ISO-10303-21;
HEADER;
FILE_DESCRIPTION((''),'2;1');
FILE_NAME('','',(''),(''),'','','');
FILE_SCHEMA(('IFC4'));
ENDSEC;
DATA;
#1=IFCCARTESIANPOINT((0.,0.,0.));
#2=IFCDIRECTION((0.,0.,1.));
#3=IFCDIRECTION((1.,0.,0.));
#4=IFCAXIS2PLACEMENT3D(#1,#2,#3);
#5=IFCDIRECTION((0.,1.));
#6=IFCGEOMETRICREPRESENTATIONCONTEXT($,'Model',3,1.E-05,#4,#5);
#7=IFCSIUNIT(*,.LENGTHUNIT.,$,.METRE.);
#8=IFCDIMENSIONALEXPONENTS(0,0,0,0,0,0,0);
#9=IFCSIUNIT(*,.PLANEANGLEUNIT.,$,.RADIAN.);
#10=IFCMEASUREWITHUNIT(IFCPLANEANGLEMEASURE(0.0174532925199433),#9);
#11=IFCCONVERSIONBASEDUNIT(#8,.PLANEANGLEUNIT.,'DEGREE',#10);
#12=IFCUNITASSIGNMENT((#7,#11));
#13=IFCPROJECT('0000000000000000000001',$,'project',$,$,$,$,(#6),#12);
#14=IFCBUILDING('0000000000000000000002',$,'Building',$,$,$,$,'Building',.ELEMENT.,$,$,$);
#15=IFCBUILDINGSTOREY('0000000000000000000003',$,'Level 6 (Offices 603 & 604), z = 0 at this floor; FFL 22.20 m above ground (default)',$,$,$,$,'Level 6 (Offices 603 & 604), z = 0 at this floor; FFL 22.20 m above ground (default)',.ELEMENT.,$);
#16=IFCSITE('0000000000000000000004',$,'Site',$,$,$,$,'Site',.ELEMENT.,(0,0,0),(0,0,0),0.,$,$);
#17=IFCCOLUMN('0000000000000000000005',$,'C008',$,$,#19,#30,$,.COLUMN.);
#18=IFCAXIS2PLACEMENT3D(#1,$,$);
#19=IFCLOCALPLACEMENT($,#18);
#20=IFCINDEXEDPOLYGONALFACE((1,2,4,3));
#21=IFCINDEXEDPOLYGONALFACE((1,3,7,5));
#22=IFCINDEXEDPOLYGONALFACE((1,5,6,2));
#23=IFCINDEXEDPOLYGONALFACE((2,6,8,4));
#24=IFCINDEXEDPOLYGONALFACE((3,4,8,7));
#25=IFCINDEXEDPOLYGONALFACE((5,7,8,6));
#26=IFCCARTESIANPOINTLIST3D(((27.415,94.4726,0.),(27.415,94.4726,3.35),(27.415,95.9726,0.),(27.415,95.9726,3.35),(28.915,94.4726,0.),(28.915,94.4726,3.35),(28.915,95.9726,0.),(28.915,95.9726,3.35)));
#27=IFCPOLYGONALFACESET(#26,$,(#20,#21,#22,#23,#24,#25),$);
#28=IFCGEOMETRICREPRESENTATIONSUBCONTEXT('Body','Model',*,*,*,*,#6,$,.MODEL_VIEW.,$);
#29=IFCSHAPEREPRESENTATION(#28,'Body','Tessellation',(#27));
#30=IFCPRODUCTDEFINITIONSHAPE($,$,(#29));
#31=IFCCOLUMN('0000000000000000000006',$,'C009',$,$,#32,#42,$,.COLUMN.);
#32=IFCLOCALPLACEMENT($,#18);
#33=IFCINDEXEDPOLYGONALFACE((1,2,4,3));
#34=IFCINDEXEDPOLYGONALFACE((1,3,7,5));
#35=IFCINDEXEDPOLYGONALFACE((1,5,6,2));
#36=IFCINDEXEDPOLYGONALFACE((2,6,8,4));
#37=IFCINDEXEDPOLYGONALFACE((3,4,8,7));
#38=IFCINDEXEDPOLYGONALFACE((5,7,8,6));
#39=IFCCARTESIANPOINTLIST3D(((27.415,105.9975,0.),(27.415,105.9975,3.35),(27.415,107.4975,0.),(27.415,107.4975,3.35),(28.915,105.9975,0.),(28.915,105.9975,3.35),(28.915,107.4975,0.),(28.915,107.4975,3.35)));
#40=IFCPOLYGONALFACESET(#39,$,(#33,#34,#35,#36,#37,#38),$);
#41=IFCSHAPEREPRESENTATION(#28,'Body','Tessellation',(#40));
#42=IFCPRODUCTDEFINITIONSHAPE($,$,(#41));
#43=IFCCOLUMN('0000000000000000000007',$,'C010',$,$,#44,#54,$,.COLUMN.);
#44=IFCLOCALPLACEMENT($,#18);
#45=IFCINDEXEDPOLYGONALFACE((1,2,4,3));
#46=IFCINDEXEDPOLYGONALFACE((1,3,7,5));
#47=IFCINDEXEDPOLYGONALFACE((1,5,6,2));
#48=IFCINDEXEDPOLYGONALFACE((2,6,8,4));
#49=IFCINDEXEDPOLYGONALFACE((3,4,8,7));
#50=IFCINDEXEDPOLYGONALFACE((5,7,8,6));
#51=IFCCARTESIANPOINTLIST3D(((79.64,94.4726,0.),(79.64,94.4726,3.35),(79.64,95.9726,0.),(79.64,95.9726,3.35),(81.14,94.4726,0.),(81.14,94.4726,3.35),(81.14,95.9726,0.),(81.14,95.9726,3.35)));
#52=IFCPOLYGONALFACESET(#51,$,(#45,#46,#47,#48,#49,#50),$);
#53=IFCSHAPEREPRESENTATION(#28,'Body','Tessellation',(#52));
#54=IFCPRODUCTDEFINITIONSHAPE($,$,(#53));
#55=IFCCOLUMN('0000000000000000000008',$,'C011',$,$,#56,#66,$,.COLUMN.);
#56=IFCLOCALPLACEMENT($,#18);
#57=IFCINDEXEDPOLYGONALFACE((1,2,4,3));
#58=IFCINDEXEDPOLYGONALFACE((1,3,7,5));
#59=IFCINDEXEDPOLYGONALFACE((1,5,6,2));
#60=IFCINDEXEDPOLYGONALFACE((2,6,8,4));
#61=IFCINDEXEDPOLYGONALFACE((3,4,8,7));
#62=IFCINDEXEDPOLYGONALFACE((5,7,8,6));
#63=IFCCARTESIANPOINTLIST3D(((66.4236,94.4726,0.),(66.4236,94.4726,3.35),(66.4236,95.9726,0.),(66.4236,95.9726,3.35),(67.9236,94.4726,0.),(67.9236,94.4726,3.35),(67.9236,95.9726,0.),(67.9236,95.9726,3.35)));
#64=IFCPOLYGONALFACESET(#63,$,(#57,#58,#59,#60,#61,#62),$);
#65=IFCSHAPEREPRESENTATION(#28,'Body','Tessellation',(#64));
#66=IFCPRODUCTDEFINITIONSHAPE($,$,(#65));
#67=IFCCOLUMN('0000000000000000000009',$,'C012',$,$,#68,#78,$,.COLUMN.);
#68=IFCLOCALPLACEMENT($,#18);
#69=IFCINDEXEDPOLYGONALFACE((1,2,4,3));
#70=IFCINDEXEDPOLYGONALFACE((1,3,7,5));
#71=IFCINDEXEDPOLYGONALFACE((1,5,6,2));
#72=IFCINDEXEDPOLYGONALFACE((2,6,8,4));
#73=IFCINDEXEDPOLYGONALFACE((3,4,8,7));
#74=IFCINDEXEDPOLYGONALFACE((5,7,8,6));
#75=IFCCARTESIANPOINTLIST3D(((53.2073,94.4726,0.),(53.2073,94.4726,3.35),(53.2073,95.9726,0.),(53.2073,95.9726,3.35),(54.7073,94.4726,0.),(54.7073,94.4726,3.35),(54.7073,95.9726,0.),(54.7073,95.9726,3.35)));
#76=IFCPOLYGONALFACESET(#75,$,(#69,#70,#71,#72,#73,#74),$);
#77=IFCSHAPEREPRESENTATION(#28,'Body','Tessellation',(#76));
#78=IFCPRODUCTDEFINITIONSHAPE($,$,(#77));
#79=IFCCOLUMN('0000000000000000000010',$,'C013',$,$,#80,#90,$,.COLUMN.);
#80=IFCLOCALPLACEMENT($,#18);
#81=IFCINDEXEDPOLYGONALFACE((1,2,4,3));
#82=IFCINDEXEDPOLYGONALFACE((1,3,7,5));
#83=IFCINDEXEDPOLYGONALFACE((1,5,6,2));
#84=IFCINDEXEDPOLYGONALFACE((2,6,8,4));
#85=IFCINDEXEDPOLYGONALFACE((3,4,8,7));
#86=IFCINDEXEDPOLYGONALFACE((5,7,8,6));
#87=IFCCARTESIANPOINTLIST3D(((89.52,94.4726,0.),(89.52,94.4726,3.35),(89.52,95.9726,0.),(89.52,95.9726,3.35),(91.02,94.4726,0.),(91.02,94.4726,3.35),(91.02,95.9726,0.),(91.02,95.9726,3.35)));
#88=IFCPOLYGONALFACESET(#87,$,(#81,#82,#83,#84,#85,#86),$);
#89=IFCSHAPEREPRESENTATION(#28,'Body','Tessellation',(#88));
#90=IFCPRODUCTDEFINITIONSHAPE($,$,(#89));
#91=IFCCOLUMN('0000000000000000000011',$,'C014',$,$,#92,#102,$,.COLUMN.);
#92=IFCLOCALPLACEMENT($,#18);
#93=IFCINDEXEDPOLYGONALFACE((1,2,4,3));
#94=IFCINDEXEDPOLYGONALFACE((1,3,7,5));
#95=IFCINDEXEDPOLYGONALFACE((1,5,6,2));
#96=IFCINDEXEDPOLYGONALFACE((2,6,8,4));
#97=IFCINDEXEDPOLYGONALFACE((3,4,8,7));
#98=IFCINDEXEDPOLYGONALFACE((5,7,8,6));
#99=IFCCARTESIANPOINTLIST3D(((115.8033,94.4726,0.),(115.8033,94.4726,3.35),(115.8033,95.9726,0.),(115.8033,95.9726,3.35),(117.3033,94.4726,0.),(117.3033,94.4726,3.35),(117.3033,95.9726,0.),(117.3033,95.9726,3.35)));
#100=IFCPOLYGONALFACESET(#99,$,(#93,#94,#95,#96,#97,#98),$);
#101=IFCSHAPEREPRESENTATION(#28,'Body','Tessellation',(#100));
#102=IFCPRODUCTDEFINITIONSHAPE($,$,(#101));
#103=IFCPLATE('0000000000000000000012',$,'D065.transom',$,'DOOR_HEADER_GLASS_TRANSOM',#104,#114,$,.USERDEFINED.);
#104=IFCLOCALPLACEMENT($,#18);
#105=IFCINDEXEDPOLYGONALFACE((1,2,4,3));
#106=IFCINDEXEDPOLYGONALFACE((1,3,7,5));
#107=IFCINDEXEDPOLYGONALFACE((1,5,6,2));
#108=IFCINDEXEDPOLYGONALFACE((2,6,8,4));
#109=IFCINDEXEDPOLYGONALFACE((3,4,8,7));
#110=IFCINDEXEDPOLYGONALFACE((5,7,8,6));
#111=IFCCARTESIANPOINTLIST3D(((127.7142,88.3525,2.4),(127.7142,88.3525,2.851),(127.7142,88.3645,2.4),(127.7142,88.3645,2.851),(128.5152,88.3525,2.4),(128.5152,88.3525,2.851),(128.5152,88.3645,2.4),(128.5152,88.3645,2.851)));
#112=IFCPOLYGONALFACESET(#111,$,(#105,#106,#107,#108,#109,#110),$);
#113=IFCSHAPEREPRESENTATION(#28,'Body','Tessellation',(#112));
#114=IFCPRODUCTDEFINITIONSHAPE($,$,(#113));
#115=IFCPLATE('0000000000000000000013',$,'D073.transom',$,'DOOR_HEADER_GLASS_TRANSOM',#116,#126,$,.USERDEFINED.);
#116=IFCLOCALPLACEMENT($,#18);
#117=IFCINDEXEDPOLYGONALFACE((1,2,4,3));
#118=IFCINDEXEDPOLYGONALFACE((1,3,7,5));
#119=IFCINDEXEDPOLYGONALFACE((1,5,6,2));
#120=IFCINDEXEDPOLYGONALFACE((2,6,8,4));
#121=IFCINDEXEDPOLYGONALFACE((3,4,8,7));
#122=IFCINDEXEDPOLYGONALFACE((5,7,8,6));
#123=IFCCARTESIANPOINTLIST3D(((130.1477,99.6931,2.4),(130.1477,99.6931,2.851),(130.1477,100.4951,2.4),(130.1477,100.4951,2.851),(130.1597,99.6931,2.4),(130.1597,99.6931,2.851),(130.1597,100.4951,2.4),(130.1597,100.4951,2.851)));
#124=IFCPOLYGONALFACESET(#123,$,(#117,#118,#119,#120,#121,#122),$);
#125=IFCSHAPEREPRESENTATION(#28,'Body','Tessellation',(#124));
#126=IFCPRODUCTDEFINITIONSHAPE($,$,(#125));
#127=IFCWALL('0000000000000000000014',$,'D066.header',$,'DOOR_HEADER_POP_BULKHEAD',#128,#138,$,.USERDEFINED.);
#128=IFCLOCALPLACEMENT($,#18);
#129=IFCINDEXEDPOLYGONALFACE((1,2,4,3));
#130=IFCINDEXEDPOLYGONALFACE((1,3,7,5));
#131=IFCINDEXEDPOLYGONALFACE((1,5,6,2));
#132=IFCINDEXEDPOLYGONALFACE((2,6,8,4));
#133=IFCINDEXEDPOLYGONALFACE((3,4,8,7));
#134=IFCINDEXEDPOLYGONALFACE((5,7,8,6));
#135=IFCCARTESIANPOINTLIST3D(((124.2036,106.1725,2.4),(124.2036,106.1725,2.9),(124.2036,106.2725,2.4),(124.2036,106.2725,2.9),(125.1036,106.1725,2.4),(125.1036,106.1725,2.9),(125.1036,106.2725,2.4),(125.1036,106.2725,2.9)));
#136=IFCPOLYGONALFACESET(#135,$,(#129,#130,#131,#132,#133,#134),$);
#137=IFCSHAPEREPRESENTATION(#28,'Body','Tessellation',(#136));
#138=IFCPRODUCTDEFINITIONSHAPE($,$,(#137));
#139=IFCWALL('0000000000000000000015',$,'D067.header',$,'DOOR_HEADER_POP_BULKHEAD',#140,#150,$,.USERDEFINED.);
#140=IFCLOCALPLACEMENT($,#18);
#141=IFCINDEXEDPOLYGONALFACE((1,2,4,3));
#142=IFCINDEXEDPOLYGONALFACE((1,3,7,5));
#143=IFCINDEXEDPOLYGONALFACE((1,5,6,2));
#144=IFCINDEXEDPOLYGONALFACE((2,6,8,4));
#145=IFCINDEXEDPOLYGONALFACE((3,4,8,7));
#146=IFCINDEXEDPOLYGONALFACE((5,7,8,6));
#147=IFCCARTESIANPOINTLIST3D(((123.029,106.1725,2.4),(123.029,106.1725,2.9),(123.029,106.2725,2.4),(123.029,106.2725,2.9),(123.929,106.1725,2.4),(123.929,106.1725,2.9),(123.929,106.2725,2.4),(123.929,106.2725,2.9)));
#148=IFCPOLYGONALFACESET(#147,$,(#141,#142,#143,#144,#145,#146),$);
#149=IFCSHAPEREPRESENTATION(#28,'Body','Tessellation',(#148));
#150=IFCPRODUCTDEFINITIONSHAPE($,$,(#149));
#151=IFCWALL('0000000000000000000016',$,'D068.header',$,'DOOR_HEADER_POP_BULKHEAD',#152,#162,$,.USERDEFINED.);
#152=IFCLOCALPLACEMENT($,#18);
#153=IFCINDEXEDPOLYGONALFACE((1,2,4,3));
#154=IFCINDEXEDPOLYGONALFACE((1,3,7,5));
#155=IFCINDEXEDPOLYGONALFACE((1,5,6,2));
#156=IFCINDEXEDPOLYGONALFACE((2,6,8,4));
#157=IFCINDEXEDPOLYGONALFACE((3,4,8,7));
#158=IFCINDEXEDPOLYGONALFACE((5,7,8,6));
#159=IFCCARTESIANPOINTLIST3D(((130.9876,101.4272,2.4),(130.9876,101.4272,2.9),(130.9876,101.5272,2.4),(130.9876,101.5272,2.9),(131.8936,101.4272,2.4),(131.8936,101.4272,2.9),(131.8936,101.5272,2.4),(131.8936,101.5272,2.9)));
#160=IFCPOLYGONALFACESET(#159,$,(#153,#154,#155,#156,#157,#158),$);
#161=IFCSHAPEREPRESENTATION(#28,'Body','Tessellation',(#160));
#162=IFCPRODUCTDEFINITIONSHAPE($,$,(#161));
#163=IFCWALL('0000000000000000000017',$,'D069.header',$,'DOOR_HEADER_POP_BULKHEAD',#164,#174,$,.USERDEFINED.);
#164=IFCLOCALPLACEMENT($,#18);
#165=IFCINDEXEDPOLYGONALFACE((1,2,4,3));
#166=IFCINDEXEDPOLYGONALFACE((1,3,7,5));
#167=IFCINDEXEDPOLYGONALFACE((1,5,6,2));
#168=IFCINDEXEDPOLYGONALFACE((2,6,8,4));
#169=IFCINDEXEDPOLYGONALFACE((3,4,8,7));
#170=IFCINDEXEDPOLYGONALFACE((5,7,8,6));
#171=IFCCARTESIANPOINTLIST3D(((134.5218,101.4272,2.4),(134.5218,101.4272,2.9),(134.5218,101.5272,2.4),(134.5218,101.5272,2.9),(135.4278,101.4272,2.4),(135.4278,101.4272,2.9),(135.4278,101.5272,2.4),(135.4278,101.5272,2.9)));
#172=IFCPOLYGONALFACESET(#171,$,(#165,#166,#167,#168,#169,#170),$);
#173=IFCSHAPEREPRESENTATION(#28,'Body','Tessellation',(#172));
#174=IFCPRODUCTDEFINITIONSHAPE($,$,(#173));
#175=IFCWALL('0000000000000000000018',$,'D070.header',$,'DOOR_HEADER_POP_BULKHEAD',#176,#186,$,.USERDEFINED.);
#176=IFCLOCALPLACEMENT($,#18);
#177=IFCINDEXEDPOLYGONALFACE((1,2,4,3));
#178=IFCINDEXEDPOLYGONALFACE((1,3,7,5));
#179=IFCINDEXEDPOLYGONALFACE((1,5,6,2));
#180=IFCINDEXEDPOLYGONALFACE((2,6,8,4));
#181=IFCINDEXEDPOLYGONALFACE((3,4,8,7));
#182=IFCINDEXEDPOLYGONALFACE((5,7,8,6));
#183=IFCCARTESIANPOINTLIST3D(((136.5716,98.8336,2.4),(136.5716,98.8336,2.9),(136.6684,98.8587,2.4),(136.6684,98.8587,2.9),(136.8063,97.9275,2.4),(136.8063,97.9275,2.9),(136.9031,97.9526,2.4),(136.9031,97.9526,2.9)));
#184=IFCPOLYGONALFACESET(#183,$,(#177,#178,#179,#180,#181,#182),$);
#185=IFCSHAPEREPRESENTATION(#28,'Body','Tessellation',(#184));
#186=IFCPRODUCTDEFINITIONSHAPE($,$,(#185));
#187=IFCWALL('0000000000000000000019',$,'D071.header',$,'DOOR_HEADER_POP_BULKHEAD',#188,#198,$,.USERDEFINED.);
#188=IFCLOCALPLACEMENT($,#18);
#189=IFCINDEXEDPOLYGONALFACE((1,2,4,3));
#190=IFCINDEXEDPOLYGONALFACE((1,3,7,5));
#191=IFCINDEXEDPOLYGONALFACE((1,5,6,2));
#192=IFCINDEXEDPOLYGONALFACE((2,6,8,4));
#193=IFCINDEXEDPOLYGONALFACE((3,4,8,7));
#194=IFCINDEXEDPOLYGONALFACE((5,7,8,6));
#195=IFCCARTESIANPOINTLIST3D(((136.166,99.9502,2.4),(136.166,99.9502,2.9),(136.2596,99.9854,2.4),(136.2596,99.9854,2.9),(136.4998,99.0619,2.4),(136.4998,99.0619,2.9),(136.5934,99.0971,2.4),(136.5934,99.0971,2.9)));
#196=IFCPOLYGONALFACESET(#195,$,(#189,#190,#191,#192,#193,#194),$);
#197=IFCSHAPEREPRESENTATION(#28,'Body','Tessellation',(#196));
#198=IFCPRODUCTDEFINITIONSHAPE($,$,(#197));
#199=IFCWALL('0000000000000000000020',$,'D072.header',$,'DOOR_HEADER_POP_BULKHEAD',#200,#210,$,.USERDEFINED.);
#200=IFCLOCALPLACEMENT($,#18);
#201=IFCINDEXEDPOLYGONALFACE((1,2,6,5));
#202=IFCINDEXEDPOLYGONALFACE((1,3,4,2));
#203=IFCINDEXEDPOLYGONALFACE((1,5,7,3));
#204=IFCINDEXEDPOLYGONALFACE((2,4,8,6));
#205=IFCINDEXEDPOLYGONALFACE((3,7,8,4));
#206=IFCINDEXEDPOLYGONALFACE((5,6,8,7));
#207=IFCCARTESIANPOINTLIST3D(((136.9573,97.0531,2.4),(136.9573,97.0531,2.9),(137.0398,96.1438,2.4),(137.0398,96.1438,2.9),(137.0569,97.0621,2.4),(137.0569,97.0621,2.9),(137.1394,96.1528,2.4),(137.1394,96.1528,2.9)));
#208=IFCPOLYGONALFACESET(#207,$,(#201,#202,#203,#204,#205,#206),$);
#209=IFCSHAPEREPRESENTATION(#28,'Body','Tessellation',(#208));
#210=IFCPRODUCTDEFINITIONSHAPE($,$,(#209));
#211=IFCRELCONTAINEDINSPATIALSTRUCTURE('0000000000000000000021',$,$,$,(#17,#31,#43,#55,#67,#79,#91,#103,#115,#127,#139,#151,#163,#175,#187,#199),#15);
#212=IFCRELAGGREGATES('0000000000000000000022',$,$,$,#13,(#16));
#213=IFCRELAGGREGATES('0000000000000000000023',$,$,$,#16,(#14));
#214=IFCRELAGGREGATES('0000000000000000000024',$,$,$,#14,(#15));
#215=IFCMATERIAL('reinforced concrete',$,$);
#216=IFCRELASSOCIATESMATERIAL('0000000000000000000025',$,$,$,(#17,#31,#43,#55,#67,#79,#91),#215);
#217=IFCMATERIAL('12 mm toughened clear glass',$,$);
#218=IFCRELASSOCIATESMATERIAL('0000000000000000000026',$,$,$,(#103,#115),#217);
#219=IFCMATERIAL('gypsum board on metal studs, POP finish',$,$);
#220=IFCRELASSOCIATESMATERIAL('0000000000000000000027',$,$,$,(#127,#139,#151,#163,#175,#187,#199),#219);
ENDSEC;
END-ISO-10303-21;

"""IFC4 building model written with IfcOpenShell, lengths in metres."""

from ifc_helpers import new_model, entity, si_unit, converted_unit, direction, frame, frame_2d, origin_with_axes, origin_2d_with_axis, place, context, subcontext, project, spatial, rectangle, extrude, material, element, save


model = new_model("IFC4")

# Units and contexts
model_context = context("Model", 3, precision=1e-05, world=origin_with_axes(), true_north=direction((0.0, 1.0)))
body_context = subcontext(model_context, "Body", "Model", "MODEL_VIEW")
ifc_project = project(units=[si_unit("LENGTHUNIT", "METRE"), converted_unit("PLANEANGLEUNIT", "DEGREE", entity("IfcPlaneAngleMeasure", 0.0174532925199433), si_unit("PLANEANGLEUNIT", "RADIAN"), dimensions=[0, 0, 0, 0, 0, 0, 0])], contexts=[model_context])

# Site, building, storey
site = spatial("IfcSite", under=ifc_project, Name="Site", LongName="Site", CompositionType="ELEMENT", RefLatitude=(0, 0, 0), RefLongitude=(0, 0, 0), RefElevation=0.0)
building = spatial("IfcBuilding", under=site, Name="Building", LongName="Building", CompositionType="ELEMENT")
storey = spatial("IfcBuildingStorey", under=building, Name="Level 6 (Offices 603 & 604), z = 0 at this floor; FFL 22.20 m above ground (default)", LongName="Level 6 (Offices 603 & 604), z = 0 at this floor; FFL 22.20 m above ground (default)", CompositionType="ELEMENT")

# Columns
ifc_material_1 = material(Name="reinforced concrete")
placement = place(None, origin_with_axes())
element("IfcColumn", 1, at=placement, inside=storey, material=ifc_material_1, Name="C008", PredefinedType="COLUMN", context=body_context, shape_type="SweptSolid", body=[
    extrude(rectangle(XDim=1.5, YDim=1.5, at=origin_2d_with_axis()), frame((28.165, 95.2226, 0.0), z_axis=(0.0, 0.0, 1.0), x_axis=(1.0, 0.0, 0.0)), (0.0, 0.0, 1.0), 3.35),
])
element("IfcColumn", 2, at=placement, inside=storey, material=ifc_material_1, Name="C009", PredefinedType="COLUMN", context=body_context, shape_type="SweptSolid", body=[
    extrude(rectangle(XDim=1.5, YDim=1.5, at=origin_2d_with_axis()), frame((28.165, 106.7475, 0.0), z_axis=(0.0, 0.0, 1.0), x_axis=(1.0, 0.0, 0.0)), (0.0, 0.0, 1.0), 3.35),
])
element("IfcColumn", 3, at=placement, inside=storey, material=ifc_material_1, Name="C010", PredefinedType="COLUMN", context=body_context, shape_type="SweptSolid", body=[
    extrude(rectangle(XDim=1.5, YDim=1.5, at=origin_2d_with_axis()), frame((80.39, 95.2226, 0.0), z_axis=(0.0, 0.0, 1.0), x_axis=(1.0, 0.0, 0.0)), (0.0, 0.0, 1.0), 3.35),
])
element("IfcColumn", 4, at=placement, inside=storey, material=ifc_material_1, Name="C011", PredefinedType="COLUMN", context=body_context, shape_type="SweptSolid", body=[
    extrude(rectangle(XDim=1.5, YDim=1.5, at=origin_2d_with_axis()), frame((67.1736, 95.2226, 0.0), z_axis=(0.0, 0.0, 1.0), x_axis=(1.0, 0.0, 0.0)), (0.0, 0.0, 1.0), 3.35),
])
element("IfcColumn", 5, at=placement, inside=storey, material=ifc_material_1, Name="C012", PredefinedType="COLUMN", context=body_context, shape_type="SweptSolid", body=[
    extrude(rectangle(XDim=1.5, YDim=1.5, at=origin_2d_with_axis()), frame((53.9573, 95.2226, 0.0), z_axis=(0.0, 0.0, 1.0), x_axis=(1.0, 0.0, 0.0)), (0.0, 0.0, 1.0), 3.35),
])
element("IfcColumn", 6, at=placement, inside=storey, material=ifc_material_1, Name="C013", PredefinedType="COLUMN", context=body_context, shape_type="SweptSolid", body=[
    extrude(rectangle(XDim=1.5, YDim=1.5, at=origin_2d_with_axis()), frame((90.27, 95.2226, 0.0), z_axis=(0.0, 0.0, 1.0), x_axis=(1.0, 0.0, 0.0)), (0.0, 0.0, 1.0), 3.35),
])
element("IfcColumn", 7, at=placement, inside=storey, material=ifc_material_1, Name="C014", PredefinedType="COLUMN", context=body_context, shape_type="SweptSolid", body=[
    extrude(rectangle(XDim=1.5, YDim=1.5, at=origin_2d_with_axis()), frame((116.5533, 95.2226, 0.0), z_axis=(0.0, 0.0, 1.0), x_axis=(1.0, 0.0, 0.0)), (0.0, 0.0, 1.0), 3.35),
])

# Plates
ifc_material_2 = material(Name="12 mm toughened clear glass")
element("IfcPlate", 8, at=placement, inside=storey, material=ifc_material_2, Name="D065.transom", ObjectType="DOOR_HEADER_GLASS_TRANSOM", PredefinedType="USERDEFINED", context=body_context, shape_type="SweptSolid", body=[
    extrude(rectangle(XDim=0.801, YDim=0.012, at=origin_2d_with_axis()), frame((128.1147, 88.3585, 2.4), z_axis=(0.0, 0.0, 1.0), x_axis=(1.0, 0.0, 0.0)), (0.0, 0.0, 1.0), 0.451),
])
element("IfcPlate", 9, at=placement, inside=storey, material=ifc_material_2, Name="D073.transom", ObjectType="DOOR_HEADER_GLASS_TRANSOM", PredefinedType="USERDEFINED", context=body_context, shape_type="SweptSolid", body=[
    extrude(rectangle(XDim=0.802, YDim=0.012, at=frame_2d((0.0, 0.0), x_axis=(0.0, 1.0))), frame((130.1537, 100.0941, 2.4), z_axis=(0.0, 0.0, 1.0), x_axis=(1.0, 0.0, 0.0)), (0.0, 0.0, 1.0), 0.451),
])

# Walls
ifc_material_3 = material(Name="gypsum board on metal studs, POP finish")
element("IfcWall", 10, at=placement, inside=storey, material=ifc_material_3, Name="D066.header", ObjectType="DOOR_HEADER_POP_BULKHEAD", PredefinedType="USERDEFINED", context=body_context, shape_type="SweptSolid", body=[
    extrude(rectangle(XDim=0.9, YDim=0.1, at=origin_2d_with_axis()), frame((124.6536, 106.2225, 2.4), z_axis=(0.0, 0.0, 1.0), x_axis=(1.0, 0.0, 0.0)), (0.0, 0.0, 1.0), 0.5),
])
element("IfcWall", 11, at=placement, inside=storey, material=ifc_material_3, Name="D067.header", ObjectType="DOOR_HEADER_POP_BULKHEAD", PredefinedType="USERDEFINED", context=body_context, shape_type="SweptSolid", body=[
    extrude(rectangle(XDim=0.9, YDim=0.1, at=origin_2d_with_axis()), frame((123.479, 106.2225, 2.4), z_axis=(0.0, 0.0, 1.0), x_axis=(1.0, 0.0, 0.0)), (0.0, 0.0, 1.0), 0.5),
])
element("IfcWall", 12, at=placement, inside=storey, material=ifc_material_3, Name="D068.header", ObjectType="DOOR_HEADER_POP_BULKHEAD", PredefinedType="USERDEFINED", context=body_context, shape_type="SweptSolid", body=[
    extrude(rectangle(XDim=0.906, YDim=0.1, at=origin_2d_with_axis()), frame((131.4407, 101.4772, 2.4), z_axis=(0.0, 0.0, 1.0), x_axis=(1.0, 0.0, 0.0)), (0.0, 0.0, 1.0), 0.5),
])
element("IfcWall", 13, at=placement, inside=storey, material=ifc_material_3, Name="D069.header", ObjectType="DOOR_HEADER_POP_BULKHEAD", PredefinedType="USERDEFINED", context=body_context, shape_type="SweptSolid", body=[
    extrude(rectangle(XDim=0.906, YDim=0.1, at=origin_2d_with_axis()), frame((134.9749, 101.4772, 2.4), z_axis=(0.0, 0.0, 1.0), x_axis=(1.0, 0.0, 0.0)), (0.0, 0.0, 1.0), 0.5),
])
element("IfcWall", 14, at=placement, inside=storey, material=ifc_material_3, Name="D070.header", ObjectType="DOOR_HEADER_POP_BULKHEAD", PredefinedType="USERDEFINED", context=body_context, shape_type="SweptSolid", body=[
    extrude(rectangle(XDim=0.936, YDim=0.1, at=frame_2d((0.0, 0.0), x_axis=(0.250669, -0.968073))), frame((136.7373, 98.3931, 2.4), z_axis=(0.0, 0.0, 1.0), x_axis=(1.0, 0.0, 0.0)), (0.0, 0.0, 1.0), 0.5),
])
element("IfcWall", 15, at=placement, inside=storey, material=ifc_material_3, Name="D071.header", ObjectType="DOOR_HEADER_POP_BULKHEAD", PredefinedType="USERDEFINED", context=body_context, shape_type="SweptSolid", body=[
    extrude(rectangle(XDim=0.949, YDim=0.1, at=frame_2d((0.0, 0.0), x_axis=(0.351804, -0.936074))), frame((136.3797, 99.5237, 2.4), z_axis=(0.0, 0.0, 1.0), x_axis=(1.0, 0.0, 0.0)), (0.0, 0.0, 1.0), 0.5),
])
element("IfcWall", 16, at=placement, inside=storey, material=ifc_material_3, Name="D072.header", ObjectType="DOOR_HEADER_POP_BULKHEAD", PredefinedType="USERDEFINED", context=body_context, shape_type="SweptSolid", body=[
    extrude(rectangle(XDim=0.913, YDim=0.1, at=frame_2d((0.0, 0.0), x_axis=(0.090319, -0.995913))), frame((137.0483, 96.603, 2.4), z_axis=(0.0, 0.0, 1.0), x_axis=(1.0, 0.0, 0.0)), (0.0, 0.0, 1.0), 0.5),
])

save(model, "model.ifc")
